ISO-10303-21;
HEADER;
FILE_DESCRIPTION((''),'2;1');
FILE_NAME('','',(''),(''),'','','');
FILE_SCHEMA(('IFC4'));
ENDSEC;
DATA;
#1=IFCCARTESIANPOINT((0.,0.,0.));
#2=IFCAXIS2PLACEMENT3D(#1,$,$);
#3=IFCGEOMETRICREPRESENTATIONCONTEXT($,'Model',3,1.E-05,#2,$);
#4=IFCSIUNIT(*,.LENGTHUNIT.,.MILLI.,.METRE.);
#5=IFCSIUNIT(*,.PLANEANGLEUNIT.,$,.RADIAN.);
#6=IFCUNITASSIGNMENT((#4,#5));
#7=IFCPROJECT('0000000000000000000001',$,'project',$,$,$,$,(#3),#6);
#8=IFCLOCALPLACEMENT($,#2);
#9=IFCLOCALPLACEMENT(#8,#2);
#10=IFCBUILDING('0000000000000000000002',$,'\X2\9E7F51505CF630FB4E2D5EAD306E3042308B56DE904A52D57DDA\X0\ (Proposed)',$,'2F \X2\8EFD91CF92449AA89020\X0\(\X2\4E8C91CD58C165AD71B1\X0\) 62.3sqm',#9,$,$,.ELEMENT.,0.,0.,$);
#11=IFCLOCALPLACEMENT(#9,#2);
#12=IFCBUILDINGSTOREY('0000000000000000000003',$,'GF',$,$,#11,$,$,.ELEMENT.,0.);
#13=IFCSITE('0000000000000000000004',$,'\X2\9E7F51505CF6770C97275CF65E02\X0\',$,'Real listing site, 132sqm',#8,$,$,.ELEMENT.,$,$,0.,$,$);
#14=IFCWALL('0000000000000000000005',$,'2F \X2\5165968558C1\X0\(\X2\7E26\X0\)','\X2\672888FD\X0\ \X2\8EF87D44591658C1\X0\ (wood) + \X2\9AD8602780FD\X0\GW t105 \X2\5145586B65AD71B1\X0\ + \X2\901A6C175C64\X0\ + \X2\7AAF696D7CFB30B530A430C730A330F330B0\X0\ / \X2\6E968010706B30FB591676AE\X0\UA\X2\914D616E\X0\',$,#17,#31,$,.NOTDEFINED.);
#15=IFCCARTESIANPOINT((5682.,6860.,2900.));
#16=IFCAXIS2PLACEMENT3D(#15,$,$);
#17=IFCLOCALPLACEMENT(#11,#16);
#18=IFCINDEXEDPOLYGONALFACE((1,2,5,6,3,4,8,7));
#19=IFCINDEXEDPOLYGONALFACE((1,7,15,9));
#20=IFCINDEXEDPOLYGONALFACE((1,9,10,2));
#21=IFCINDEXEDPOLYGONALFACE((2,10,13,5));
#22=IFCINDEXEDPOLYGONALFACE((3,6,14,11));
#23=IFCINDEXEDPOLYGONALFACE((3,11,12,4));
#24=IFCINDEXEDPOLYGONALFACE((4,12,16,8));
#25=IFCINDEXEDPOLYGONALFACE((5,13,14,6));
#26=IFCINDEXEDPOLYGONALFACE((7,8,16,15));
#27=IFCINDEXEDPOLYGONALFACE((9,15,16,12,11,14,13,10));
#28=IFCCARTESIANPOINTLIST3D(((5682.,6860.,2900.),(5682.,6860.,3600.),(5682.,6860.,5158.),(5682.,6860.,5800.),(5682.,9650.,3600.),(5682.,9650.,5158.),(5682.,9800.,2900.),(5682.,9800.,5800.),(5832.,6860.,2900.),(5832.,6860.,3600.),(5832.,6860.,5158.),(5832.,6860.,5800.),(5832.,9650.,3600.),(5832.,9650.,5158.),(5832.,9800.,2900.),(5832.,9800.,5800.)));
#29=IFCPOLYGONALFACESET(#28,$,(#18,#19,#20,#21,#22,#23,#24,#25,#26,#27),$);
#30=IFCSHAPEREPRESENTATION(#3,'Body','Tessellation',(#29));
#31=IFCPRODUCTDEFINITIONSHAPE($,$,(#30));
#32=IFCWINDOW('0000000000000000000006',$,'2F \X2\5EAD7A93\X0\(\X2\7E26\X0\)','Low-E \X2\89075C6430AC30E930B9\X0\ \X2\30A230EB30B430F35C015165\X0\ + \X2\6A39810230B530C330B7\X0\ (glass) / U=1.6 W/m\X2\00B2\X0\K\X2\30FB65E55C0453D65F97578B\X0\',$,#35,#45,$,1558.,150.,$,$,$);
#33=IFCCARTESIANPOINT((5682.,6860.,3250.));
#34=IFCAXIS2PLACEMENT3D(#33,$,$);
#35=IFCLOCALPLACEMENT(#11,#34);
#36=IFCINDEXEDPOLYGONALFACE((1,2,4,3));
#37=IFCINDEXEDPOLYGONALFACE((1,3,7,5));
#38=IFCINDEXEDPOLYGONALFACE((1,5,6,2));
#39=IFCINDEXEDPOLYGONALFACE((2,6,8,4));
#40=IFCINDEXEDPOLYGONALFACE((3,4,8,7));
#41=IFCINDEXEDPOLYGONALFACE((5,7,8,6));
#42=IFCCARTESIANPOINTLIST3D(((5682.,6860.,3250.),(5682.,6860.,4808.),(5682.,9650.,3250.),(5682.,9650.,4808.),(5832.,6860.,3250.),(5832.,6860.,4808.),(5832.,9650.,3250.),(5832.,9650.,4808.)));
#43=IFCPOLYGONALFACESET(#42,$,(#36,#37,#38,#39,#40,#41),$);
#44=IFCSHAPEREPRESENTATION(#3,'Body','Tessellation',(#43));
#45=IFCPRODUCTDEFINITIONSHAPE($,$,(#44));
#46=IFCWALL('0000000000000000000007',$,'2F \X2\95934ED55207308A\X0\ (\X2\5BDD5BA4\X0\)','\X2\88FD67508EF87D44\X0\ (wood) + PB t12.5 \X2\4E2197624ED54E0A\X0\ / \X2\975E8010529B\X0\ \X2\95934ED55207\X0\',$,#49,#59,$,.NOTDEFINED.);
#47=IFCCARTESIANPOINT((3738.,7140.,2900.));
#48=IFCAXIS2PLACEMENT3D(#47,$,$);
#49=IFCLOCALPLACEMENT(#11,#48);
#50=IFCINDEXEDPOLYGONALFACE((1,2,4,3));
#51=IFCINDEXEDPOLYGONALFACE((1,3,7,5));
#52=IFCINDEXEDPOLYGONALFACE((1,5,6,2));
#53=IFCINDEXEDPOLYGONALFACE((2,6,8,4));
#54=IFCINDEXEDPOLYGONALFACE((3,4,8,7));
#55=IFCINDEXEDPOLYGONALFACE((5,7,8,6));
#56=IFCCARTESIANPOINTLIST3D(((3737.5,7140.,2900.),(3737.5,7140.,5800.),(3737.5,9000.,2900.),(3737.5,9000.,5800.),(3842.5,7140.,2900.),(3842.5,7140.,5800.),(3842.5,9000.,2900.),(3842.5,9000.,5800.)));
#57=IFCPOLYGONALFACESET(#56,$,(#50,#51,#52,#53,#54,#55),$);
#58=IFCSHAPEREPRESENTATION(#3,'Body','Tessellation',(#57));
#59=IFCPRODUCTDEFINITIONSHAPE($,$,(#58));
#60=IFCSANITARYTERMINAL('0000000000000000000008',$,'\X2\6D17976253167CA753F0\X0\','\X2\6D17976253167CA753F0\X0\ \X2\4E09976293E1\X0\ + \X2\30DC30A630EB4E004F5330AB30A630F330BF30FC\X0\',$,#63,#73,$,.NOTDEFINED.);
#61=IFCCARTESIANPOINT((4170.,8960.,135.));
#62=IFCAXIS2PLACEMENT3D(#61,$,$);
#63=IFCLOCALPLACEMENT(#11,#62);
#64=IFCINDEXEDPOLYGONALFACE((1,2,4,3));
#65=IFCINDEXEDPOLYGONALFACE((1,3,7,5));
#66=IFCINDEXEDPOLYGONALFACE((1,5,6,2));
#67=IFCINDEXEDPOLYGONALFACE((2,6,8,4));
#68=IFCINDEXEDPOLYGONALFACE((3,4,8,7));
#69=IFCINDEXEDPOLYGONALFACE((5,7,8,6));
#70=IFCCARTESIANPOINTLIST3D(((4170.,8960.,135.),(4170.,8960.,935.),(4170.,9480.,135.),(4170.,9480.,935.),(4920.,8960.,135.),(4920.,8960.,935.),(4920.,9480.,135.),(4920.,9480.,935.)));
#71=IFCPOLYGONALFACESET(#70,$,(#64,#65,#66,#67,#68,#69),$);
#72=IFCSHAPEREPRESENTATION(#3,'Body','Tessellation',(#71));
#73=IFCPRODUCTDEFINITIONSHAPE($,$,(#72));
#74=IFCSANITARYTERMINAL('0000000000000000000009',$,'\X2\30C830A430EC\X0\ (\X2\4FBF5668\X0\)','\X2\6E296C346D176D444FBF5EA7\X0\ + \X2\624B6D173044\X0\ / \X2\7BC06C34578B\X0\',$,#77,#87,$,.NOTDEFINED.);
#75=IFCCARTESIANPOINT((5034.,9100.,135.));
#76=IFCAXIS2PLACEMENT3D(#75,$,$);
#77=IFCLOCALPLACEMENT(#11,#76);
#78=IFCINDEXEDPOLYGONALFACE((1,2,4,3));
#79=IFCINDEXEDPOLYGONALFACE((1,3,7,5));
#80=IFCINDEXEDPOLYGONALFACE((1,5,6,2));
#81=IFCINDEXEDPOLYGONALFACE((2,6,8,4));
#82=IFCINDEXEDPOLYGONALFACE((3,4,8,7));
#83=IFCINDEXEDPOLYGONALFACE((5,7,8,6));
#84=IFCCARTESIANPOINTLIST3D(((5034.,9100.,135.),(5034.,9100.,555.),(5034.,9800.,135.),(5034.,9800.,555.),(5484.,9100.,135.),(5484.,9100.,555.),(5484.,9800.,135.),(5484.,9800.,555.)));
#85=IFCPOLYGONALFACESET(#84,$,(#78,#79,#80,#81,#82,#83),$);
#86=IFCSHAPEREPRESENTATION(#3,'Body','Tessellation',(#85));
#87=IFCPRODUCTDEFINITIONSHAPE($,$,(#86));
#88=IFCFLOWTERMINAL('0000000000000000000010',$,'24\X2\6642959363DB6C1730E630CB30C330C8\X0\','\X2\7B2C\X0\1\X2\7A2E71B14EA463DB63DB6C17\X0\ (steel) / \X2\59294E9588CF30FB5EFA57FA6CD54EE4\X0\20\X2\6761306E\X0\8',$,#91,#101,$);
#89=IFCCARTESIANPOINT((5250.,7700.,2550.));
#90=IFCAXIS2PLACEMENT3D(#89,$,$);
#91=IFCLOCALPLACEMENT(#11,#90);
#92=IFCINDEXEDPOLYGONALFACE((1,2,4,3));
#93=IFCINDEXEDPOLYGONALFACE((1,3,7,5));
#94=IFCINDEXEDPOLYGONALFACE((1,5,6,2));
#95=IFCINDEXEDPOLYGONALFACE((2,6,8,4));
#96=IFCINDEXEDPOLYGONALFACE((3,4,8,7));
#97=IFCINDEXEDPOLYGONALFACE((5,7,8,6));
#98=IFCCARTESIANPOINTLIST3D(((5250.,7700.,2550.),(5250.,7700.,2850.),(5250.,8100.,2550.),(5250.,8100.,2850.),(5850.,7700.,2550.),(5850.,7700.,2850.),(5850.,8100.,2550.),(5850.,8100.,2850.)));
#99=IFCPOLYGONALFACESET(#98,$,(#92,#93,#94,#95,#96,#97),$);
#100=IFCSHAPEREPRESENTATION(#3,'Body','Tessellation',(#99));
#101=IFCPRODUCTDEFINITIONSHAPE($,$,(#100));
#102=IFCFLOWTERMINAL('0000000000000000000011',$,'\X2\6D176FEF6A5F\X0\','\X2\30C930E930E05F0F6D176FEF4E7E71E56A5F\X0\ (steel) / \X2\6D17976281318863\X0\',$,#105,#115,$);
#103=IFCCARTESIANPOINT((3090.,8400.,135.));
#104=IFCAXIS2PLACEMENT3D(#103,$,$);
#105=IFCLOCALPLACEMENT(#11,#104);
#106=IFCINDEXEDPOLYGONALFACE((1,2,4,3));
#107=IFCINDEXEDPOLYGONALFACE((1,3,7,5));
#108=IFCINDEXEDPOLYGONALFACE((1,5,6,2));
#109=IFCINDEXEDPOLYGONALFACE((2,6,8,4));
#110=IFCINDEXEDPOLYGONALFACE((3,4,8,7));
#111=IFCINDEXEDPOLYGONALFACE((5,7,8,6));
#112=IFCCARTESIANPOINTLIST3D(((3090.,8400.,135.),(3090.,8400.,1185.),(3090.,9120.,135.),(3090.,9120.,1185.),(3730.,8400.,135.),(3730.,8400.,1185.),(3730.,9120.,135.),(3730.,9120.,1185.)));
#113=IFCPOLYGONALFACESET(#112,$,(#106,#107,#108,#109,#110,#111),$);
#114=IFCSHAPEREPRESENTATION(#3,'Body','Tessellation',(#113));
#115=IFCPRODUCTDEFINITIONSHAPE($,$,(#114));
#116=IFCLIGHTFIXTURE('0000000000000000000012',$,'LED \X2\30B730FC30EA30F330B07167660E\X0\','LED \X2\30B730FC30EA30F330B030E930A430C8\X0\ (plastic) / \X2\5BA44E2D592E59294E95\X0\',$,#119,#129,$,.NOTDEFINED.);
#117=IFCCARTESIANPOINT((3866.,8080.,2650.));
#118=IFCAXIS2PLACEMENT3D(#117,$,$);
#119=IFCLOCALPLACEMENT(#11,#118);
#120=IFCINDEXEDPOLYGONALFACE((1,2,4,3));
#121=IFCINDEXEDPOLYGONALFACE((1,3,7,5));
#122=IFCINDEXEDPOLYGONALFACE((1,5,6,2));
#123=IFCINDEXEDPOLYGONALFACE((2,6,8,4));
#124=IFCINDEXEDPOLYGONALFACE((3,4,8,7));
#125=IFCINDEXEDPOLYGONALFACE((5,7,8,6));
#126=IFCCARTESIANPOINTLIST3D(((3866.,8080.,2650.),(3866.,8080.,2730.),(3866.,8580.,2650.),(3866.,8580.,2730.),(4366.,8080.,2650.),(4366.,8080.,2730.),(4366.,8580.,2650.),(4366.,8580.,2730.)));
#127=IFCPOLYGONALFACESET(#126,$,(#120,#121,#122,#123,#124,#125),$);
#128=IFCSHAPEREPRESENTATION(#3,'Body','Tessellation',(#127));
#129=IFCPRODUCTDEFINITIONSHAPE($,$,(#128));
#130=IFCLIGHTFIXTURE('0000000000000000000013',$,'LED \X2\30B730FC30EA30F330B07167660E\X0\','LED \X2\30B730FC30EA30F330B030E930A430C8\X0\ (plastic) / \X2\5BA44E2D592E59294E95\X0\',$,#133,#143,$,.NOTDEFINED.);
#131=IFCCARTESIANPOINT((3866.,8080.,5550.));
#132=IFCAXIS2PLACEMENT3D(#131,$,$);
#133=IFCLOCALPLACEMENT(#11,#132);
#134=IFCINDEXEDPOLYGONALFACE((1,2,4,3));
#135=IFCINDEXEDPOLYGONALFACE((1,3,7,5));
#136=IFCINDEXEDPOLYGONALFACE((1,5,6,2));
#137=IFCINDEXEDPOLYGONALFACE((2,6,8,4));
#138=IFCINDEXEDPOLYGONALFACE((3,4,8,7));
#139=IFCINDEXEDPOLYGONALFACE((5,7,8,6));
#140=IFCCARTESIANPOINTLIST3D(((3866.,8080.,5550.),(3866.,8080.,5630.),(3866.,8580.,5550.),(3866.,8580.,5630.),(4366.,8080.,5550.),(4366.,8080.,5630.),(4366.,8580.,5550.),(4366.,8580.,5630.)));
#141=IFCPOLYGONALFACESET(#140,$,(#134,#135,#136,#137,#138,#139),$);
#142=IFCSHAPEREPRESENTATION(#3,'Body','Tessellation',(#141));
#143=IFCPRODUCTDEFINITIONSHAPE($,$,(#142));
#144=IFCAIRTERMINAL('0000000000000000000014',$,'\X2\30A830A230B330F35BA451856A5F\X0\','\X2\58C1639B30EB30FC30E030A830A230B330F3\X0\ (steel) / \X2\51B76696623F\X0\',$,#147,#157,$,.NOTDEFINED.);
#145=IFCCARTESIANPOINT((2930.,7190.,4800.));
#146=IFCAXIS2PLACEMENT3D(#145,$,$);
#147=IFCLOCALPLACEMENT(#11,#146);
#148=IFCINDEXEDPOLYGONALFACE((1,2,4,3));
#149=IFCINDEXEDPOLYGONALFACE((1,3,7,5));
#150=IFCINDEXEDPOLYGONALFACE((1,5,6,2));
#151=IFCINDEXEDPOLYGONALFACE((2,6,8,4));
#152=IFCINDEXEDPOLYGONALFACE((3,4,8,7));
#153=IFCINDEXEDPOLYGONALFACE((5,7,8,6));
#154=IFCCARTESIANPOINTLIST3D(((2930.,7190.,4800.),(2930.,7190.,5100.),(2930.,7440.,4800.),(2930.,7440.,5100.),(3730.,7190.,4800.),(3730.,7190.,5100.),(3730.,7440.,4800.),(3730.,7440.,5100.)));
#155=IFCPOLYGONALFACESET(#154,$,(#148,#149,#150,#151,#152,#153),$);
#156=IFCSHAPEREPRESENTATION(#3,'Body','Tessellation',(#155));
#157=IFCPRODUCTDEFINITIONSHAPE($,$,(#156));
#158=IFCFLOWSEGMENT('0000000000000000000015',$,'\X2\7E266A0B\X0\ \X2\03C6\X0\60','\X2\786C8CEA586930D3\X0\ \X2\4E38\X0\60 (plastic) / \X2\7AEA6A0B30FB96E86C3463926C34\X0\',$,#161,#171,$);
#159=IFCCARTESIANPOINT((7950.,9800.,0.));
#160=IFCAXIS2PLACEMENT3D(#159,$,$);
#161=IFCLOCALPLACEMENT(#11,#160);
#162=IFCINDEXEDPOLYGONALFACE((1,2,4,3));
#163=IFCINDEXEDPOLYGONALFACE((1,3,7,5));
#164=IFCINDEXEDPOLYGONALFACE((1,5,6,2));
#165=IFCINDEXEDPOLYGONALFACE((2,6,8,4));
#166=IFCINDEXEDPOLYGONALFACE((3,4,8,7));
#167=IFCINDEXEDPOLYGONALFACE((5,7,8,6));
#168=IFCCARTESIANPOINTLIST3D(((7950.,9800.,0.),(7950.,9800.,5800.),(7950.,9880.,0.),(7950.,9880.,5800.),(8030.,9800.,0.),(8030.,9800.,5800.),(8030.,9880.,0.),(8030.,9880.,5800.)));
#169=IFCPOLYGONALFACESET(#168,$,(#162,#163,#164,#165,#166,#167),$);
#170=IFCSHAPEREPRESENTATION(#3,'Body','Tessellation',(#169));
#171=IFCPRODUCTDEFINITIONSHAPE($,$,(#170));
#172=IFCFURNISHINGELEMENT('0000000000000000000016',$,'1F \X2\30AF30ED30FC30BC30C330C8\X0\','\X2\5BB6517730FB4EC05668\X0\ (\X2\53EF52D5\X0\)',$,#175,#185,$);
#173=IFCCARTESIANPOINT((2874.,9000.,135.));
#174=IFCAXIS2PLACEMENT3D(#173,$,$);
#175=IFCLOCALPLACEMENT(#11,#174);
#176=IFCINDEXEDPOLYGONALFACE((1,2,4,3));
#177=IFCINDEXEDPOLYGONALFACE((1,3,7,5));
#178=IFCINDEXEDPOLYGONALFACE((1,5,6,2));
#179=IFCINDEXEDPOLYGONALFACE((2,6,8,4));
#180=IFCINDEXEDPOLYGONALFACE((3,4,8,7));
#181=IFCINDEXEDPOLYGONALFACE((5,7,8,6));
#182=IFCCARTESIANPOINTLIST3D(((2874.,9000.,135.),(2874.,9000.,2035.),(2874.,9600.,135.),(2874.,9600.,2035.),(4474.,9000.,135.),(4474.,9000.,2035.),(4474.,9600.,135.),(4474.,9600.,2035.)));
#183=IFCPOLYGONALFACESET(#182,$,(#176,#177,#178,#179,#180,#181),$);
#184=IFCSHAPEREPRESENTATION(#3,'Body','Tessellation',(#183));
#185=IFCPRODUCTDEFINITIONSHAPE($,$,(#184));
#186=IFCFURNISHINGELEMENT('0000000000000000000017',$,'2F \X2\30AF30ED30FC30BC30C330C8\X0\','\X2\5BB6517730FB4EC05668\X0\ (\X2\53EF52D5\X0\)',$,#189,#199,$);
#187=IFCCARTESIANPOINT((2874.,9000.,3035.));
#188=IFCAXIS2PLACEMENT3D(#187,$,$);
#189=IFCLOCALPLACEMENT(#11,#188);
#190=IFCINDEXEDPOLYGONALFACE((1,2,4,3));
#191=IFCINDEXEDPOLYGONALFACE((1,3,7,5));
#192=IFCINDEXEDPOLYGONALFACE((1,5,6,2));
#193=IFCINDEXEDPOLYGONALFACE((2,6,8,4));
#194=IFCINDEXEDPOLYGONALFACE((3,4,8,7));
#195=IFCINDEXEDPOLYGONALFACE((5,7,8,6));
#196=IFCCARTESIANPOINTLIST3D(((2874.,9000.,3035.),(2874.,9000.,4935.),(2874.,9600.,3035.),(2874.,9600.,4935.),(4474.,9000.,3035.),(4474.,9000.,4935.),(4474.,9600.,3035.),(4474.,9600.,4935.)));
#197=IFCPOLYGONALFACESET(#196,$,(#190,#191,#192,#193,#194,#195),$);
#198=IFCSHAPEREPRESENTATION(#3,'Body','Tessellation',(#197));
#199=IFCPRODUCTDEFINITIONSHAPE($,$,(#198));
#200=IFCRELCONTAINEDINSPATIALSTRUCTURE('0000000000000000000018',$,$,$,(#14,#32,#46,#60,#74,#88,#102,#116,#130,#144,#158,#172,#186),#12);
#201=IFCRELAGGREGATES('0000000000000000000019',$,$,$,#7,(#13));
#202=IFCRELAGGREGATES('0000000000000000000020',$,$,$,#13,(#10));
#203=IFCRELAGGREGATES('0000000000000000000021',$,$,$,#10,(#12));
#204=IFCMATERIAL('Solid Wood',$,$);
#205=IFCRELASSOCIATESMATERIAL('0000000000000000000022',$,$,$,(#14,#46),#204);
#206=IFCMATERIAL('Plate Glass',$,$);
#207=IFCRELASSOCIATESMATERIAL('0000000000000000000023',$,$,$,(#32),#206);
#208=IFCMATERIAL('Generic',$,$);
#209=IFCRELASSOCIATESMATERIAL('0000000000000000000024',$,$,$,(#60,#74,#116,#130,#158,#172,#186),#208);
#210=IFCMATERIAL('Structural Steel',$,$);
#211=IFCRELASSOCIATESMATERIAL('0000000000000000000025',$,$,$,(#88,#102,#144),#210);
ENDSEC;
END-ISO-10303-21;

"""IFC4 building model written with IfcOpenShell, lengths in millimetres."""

from ifc_helpers import new_model, si_unit, frame, frame_2d, origin, place, context, project, spatial, rectangle, extrude, material, element, fill, save


model = new_model("IFC4")

# Units and contexts
model_context = context("Model", 3, precision=1e-05, world=origin())
ifc_project = project(units=[si_unit("LENGTHUNIT", "METRE", prefix="MILLI"), si_unit("PLANEANGLEUNIT", "RADIAN")], contexts=[model_context])

# Site, building, storey
site_placement = place(None, origin())
site = spatial("IfcSite", under=ifc_project, at=site_placement, Name="鹿児島県霧島市", ObjectType="Real listing site, 132sqm", CompositionType="ELEMENT", RefElevation=0.0)
building_placement = place(site_placement, origin())
building = spatial("IfcBuilding", under=site, at=building_placement, Name="鹿児島・中庭のある回遊動線 (Proposed)", ObjectType="2F 軽量鉄骨造(二重壁断熱) 62.3sqm", CompositionType="ELEMENT", ElevationOfRefHeight=0.0, ElevationOfTerrain=0.0)
storey_placement = place(building_placement, origin())
storey = spatial("IfcBuildingStorey", under=building, at=storey_placement, Name="GF", CompositionType="ELEMENT", Elevation=0.0)

# Shared definitions
ifc_material_1 = material(Name="Solid Wood")

# Shared definitions
ifc_material_2 = material(Name="Plate Glass")

# Wall, opening, window
wall_1_placement = place(storey_placement, frame((5682.0, 6860.0, 2900.0)))
wall_1 = element("IfcWall", 1, at=wall_1_placement, inside=storey, material=ifc_material_1, Name="2F 入隅壁(縦)", Description="木製 軸組外壁 (wood) + 高性能GW t105 充填断熱 + 通気層 + 窯業系サイディング / 準耐火・外皮UA配慮", PredefinedType="NOTDEFINED", context=model_context, shape_type="SweptSolid", body=[
    extrude(rectangle(XDim=150.0, YDim=2940.0, at=frame_2d((75.0, 1470.0))), frame((5682.0, 6860.0, 2900.0)), (0.0, 0.0, 1.0), 2900.0),
])
opening_1_placement = place(storey_placement, frame((5682.0, 6860.0, 3250.0)))
opening_1 = element("IfcOpeningElement", 2, at=opening_1_placement, cuts=wall_1, PredefinedType="NOTDEFINED", context=model_context, shape_type="SweptSolid", body=[
    extrude(rectangle(XDim=150.0, YDim=2790.0, at=frame_2d((75.0, 1395.0))), frame((5682.0, 6860.0, 3250.0)), (0.0, 0.0, 1.0), 1558.0),
])
window_1_placement = place(storey_placement, frame((5682.0, 6860.0, 3250.0)))
window_1 = element("IfcWindow", 3, at=window_1_placement, inside=storey, material=ifc_material_2, Name="2F 庭窓(縦)", Description="Low-E 複層ガラス アルゴン封入 + 樹脂サッシ (glass) / U=1.6 W/m²K・日射取得型", OverallHeight=1558.0, OverallWidth=150.0, context=model_context, shape_type="SweptSolid", body=[
    extrude(rectangle(XDim=150.0, YDim=2790.0, at=frame_2d((75.0, 1395.0))), frame((5682.0, 6860.0, 3250.0)), (0.0, 0.0, 1.0), 1558.0),
])
fill(opening_1, window_1)

# Wall
wall_2_placement = place(storey_placement, frame((3738.0, 7140.0, 2900.0)))
element("IfcWall", 4, at=wall_2_placement, inside=storey, material=ifc_material_1, Name="2F 間仕切り (寝室)", Description="製材軸組 (wood) + PB t12.5 両面仕上 / 非耐力 間仕切", PredefinedType="NOTDEFINED", context=model_context, shape_type="SweptSolid", body=[
    extrude(rectangle(XDim=105.0, YDim=1860.0, at=frame_2d((52.0, 930.0))), frame((3738.0, 7140.0, 2900.0)), (0.0, 0.0, 1.0), 2900.0),
])

# Sanitary terminals
ifc_material_3 = material(Name="Generic")
sanitary_terminal_1_placement = place(storey_placement, frame((4170.0, 8960.0, 135.0)))
element("IfcSanitaryTerminal", 5, at=sanitary_terminal_1_placement, inside=storey, material=ifc_material_3, Name="洗面化粧台", Description="洗面化粧台 三面鏡 + ボウル一体カウンター", PredefinedType="NOTDEFINED", context=model_context, shape_type="SweptSolid", body=[
    extrude(rectangle(XDim=750.0, YDim=520.0, at=frame_2d((375.0, 260.0))), frame((4170.0, 8960.0, 135.0)), (0.0, 0.0, 1.0), 800.0),
])
sanitary_terminal_2_placement = place(storey_placement, frame((5034.0, 9100.0, 135.0)))
element("IfcSanitaryTerminal", 6, at=sanitary_terminal_2_placement, inside=storey, material=ifc_material_3, Name="トイレ (便器)", Description="温水洗浄便座 + 手洗い / 節水型", PredefinedType="NOTDEFINED", context=model_context, shape_type="SweptSolid", body=[
    extrude(rectangle(XDim=450.0, YDim=700.0, at=frame_2d((225.0, 350.0))), frame((5034.0, 9100.0, 135.0)), (0.0, 0.0, 1.0), 420.0),
])

# Flow terminals
ifc_material_4 = material(Name="Structural Steel")
flow_terminal_1_placement = place(storey_placement, frame((5250.0, 7700.0, 2550.0)))
element("IfcFlowTerminal", 7, at=flow_terminal_1_placement, inside=storey, material=ifc_material_4, Name="24時間換気ユニット", Description="第1種熱交換換気 (steel) / 天井裏・建基法令20条の8", context=model_context, shape_type="SweptSolid", body=[
    extrude(rectangle(XDim=600.0, YDim=400.0, at=frame_2d((300.0, 200.0))), frame((5250.0, 7700.0, 2550.0)), (0.0, 0.0, 1.0), 300.0),
])
flow_terminal_2_placement = place(storey_placement, frame((3090.0, 8400.0, 135.0)))
element("IfcFlowTerminal", 8, at=flow_terminal_2_placement, inside=storey, material=ifc_material_4, Name="洗濯機", Description="ドラム式洗濯乾燥機 (steel) / 洗面脱衣", context=model_context, shape_type="SweptSolid", body=[
    extrude(rectangle(XDim=640.0, YDim=720.0, at=frame_2d((320.0, 360.0))), frame((3090.0, 8400.0, 135.0)), (0.0, 0.0, 1.0), 1050.0),
])

# Light fixtures
light_fixture_1_placement = place(storey_placement, frame((3866.0, 8080.0, 2650.0)))
element("IfcLightFixture", 9, at=light_fixture_1_placement, inside=storey, material=ifc_material_3, Name="LED シーリング照明", Description="LED シーリングライト (plastic) / 室中央天井", PredefinedType="NOTDEFINED", context=model_context, shape_type="SweptSolid", body=[
    extrude(rectangle(XDim=500.0, YDim=500.0, at=frame_2d((250.0, 250.0))), frame((3866.0, 8080.0, 2650.0)), (0.0, 0.0, 1.0), 80.0),
])
light_fixture_2_placement = place(storey_placement, frame((3866.0, 8080.0, 5550.0)))
element("IfcLightFixture", 10, at=light_fixture_2_placement, inside=storey, material=ifc_material_3, Name="LED シーリング照明", Description="LED シーリングライト (plastic) / 室中央天井", PredefinedType="NOTDEFINED", context=model_context, shape_type="SweptSolid", body=[
    extrude(rectangle(XDim=500.0, YDim=500.0, at=frame_2d((250.0, 250.0))), frame((3866.0, 8080.0, 5550.0)), (0.0, 0.0, 1.0), 80.0),
])

# Air terminal
air_terminal_placement = place(storey_placement, frame((2930.0, 7190.0, 4800.0)))
element("IfcAirTerminal", 11, at=air_terminal_placement, inside=storey, material=ifc_material_4, Name="エアコン室内機", Description="壁掛ルームエアコン (steel) / 冷暖房", PredefinedType="NOTDEFINED", context=model_context, shape_type="SweptSolid", body=[
    extrude(rectangle(XDim=800.0, YDim=250.0, at=frame_2d((400.0, 125.0))), frame((2930.0, 7190.0, 4800.0)), (0.0, 0.0, 1.0), 300.0),
])

# Flow segment
flow_segment_placement = place(storey_placement, frame((7950.0, 9800.0, 0.0)))
element("IfcFlowSegment", 12, at=flow_segment_placement, inside=storey, material=ifc_material_3, Name="縦樋 φ60", Description="硬質塩ビ 丸60 (plastic) / 竪樋・雨水排水", context=model_context, shape_type="SweptSolid", body=[
    extrude(rectangle(XDim=80.0, YDim=80.0, at=frame_2d((40.0, 40.0))), frame((7950.0, 9800.0, 0.0)), (0.0, 0.0, 1.0), 5800.0),
])

# Furnishing elements
furnishing_1_placement = place(storey_placement, frame((2874.0, 9000.0, 135.0)))
element("IfcFurnishingElement", 13, at=furnishing_1_placement, inside=storey, material=ifc_material_3, Name="1F クローゼット", Description="家具・什器 (可動)", context=model_context, shape_type="SweptSolid", body=[
    extrude(rectangle(XDim=1600.0, YDim=600.0, at=frame_2d((800.0, 300.0))), frame((2874.0, 9000.0, 135.0)), (0.0, 0.0, 1.0), 1900.0),
])
furnishing_2_placement = place(storey_placement, frame((2874.0, 9000.0, 3035.0)))
element("IfcFurnishingElement", 14, at=furnishing_2_placement, inside=storey, material=ifc_material_3, Name="2F クローゼット", Description="家具・什器 (可動)", context=model_context, shape_type="SweptSolid", body=[
    extrude(rectangle(XDim=1600.0, YDim=600.0, at=frame_2d((800.0, 300.0))), frame((2874.0, 9000.0, 3035.0)), (0.0, 0.0, 1.0), 1900.0),
])

save(model, "model.ifc")
